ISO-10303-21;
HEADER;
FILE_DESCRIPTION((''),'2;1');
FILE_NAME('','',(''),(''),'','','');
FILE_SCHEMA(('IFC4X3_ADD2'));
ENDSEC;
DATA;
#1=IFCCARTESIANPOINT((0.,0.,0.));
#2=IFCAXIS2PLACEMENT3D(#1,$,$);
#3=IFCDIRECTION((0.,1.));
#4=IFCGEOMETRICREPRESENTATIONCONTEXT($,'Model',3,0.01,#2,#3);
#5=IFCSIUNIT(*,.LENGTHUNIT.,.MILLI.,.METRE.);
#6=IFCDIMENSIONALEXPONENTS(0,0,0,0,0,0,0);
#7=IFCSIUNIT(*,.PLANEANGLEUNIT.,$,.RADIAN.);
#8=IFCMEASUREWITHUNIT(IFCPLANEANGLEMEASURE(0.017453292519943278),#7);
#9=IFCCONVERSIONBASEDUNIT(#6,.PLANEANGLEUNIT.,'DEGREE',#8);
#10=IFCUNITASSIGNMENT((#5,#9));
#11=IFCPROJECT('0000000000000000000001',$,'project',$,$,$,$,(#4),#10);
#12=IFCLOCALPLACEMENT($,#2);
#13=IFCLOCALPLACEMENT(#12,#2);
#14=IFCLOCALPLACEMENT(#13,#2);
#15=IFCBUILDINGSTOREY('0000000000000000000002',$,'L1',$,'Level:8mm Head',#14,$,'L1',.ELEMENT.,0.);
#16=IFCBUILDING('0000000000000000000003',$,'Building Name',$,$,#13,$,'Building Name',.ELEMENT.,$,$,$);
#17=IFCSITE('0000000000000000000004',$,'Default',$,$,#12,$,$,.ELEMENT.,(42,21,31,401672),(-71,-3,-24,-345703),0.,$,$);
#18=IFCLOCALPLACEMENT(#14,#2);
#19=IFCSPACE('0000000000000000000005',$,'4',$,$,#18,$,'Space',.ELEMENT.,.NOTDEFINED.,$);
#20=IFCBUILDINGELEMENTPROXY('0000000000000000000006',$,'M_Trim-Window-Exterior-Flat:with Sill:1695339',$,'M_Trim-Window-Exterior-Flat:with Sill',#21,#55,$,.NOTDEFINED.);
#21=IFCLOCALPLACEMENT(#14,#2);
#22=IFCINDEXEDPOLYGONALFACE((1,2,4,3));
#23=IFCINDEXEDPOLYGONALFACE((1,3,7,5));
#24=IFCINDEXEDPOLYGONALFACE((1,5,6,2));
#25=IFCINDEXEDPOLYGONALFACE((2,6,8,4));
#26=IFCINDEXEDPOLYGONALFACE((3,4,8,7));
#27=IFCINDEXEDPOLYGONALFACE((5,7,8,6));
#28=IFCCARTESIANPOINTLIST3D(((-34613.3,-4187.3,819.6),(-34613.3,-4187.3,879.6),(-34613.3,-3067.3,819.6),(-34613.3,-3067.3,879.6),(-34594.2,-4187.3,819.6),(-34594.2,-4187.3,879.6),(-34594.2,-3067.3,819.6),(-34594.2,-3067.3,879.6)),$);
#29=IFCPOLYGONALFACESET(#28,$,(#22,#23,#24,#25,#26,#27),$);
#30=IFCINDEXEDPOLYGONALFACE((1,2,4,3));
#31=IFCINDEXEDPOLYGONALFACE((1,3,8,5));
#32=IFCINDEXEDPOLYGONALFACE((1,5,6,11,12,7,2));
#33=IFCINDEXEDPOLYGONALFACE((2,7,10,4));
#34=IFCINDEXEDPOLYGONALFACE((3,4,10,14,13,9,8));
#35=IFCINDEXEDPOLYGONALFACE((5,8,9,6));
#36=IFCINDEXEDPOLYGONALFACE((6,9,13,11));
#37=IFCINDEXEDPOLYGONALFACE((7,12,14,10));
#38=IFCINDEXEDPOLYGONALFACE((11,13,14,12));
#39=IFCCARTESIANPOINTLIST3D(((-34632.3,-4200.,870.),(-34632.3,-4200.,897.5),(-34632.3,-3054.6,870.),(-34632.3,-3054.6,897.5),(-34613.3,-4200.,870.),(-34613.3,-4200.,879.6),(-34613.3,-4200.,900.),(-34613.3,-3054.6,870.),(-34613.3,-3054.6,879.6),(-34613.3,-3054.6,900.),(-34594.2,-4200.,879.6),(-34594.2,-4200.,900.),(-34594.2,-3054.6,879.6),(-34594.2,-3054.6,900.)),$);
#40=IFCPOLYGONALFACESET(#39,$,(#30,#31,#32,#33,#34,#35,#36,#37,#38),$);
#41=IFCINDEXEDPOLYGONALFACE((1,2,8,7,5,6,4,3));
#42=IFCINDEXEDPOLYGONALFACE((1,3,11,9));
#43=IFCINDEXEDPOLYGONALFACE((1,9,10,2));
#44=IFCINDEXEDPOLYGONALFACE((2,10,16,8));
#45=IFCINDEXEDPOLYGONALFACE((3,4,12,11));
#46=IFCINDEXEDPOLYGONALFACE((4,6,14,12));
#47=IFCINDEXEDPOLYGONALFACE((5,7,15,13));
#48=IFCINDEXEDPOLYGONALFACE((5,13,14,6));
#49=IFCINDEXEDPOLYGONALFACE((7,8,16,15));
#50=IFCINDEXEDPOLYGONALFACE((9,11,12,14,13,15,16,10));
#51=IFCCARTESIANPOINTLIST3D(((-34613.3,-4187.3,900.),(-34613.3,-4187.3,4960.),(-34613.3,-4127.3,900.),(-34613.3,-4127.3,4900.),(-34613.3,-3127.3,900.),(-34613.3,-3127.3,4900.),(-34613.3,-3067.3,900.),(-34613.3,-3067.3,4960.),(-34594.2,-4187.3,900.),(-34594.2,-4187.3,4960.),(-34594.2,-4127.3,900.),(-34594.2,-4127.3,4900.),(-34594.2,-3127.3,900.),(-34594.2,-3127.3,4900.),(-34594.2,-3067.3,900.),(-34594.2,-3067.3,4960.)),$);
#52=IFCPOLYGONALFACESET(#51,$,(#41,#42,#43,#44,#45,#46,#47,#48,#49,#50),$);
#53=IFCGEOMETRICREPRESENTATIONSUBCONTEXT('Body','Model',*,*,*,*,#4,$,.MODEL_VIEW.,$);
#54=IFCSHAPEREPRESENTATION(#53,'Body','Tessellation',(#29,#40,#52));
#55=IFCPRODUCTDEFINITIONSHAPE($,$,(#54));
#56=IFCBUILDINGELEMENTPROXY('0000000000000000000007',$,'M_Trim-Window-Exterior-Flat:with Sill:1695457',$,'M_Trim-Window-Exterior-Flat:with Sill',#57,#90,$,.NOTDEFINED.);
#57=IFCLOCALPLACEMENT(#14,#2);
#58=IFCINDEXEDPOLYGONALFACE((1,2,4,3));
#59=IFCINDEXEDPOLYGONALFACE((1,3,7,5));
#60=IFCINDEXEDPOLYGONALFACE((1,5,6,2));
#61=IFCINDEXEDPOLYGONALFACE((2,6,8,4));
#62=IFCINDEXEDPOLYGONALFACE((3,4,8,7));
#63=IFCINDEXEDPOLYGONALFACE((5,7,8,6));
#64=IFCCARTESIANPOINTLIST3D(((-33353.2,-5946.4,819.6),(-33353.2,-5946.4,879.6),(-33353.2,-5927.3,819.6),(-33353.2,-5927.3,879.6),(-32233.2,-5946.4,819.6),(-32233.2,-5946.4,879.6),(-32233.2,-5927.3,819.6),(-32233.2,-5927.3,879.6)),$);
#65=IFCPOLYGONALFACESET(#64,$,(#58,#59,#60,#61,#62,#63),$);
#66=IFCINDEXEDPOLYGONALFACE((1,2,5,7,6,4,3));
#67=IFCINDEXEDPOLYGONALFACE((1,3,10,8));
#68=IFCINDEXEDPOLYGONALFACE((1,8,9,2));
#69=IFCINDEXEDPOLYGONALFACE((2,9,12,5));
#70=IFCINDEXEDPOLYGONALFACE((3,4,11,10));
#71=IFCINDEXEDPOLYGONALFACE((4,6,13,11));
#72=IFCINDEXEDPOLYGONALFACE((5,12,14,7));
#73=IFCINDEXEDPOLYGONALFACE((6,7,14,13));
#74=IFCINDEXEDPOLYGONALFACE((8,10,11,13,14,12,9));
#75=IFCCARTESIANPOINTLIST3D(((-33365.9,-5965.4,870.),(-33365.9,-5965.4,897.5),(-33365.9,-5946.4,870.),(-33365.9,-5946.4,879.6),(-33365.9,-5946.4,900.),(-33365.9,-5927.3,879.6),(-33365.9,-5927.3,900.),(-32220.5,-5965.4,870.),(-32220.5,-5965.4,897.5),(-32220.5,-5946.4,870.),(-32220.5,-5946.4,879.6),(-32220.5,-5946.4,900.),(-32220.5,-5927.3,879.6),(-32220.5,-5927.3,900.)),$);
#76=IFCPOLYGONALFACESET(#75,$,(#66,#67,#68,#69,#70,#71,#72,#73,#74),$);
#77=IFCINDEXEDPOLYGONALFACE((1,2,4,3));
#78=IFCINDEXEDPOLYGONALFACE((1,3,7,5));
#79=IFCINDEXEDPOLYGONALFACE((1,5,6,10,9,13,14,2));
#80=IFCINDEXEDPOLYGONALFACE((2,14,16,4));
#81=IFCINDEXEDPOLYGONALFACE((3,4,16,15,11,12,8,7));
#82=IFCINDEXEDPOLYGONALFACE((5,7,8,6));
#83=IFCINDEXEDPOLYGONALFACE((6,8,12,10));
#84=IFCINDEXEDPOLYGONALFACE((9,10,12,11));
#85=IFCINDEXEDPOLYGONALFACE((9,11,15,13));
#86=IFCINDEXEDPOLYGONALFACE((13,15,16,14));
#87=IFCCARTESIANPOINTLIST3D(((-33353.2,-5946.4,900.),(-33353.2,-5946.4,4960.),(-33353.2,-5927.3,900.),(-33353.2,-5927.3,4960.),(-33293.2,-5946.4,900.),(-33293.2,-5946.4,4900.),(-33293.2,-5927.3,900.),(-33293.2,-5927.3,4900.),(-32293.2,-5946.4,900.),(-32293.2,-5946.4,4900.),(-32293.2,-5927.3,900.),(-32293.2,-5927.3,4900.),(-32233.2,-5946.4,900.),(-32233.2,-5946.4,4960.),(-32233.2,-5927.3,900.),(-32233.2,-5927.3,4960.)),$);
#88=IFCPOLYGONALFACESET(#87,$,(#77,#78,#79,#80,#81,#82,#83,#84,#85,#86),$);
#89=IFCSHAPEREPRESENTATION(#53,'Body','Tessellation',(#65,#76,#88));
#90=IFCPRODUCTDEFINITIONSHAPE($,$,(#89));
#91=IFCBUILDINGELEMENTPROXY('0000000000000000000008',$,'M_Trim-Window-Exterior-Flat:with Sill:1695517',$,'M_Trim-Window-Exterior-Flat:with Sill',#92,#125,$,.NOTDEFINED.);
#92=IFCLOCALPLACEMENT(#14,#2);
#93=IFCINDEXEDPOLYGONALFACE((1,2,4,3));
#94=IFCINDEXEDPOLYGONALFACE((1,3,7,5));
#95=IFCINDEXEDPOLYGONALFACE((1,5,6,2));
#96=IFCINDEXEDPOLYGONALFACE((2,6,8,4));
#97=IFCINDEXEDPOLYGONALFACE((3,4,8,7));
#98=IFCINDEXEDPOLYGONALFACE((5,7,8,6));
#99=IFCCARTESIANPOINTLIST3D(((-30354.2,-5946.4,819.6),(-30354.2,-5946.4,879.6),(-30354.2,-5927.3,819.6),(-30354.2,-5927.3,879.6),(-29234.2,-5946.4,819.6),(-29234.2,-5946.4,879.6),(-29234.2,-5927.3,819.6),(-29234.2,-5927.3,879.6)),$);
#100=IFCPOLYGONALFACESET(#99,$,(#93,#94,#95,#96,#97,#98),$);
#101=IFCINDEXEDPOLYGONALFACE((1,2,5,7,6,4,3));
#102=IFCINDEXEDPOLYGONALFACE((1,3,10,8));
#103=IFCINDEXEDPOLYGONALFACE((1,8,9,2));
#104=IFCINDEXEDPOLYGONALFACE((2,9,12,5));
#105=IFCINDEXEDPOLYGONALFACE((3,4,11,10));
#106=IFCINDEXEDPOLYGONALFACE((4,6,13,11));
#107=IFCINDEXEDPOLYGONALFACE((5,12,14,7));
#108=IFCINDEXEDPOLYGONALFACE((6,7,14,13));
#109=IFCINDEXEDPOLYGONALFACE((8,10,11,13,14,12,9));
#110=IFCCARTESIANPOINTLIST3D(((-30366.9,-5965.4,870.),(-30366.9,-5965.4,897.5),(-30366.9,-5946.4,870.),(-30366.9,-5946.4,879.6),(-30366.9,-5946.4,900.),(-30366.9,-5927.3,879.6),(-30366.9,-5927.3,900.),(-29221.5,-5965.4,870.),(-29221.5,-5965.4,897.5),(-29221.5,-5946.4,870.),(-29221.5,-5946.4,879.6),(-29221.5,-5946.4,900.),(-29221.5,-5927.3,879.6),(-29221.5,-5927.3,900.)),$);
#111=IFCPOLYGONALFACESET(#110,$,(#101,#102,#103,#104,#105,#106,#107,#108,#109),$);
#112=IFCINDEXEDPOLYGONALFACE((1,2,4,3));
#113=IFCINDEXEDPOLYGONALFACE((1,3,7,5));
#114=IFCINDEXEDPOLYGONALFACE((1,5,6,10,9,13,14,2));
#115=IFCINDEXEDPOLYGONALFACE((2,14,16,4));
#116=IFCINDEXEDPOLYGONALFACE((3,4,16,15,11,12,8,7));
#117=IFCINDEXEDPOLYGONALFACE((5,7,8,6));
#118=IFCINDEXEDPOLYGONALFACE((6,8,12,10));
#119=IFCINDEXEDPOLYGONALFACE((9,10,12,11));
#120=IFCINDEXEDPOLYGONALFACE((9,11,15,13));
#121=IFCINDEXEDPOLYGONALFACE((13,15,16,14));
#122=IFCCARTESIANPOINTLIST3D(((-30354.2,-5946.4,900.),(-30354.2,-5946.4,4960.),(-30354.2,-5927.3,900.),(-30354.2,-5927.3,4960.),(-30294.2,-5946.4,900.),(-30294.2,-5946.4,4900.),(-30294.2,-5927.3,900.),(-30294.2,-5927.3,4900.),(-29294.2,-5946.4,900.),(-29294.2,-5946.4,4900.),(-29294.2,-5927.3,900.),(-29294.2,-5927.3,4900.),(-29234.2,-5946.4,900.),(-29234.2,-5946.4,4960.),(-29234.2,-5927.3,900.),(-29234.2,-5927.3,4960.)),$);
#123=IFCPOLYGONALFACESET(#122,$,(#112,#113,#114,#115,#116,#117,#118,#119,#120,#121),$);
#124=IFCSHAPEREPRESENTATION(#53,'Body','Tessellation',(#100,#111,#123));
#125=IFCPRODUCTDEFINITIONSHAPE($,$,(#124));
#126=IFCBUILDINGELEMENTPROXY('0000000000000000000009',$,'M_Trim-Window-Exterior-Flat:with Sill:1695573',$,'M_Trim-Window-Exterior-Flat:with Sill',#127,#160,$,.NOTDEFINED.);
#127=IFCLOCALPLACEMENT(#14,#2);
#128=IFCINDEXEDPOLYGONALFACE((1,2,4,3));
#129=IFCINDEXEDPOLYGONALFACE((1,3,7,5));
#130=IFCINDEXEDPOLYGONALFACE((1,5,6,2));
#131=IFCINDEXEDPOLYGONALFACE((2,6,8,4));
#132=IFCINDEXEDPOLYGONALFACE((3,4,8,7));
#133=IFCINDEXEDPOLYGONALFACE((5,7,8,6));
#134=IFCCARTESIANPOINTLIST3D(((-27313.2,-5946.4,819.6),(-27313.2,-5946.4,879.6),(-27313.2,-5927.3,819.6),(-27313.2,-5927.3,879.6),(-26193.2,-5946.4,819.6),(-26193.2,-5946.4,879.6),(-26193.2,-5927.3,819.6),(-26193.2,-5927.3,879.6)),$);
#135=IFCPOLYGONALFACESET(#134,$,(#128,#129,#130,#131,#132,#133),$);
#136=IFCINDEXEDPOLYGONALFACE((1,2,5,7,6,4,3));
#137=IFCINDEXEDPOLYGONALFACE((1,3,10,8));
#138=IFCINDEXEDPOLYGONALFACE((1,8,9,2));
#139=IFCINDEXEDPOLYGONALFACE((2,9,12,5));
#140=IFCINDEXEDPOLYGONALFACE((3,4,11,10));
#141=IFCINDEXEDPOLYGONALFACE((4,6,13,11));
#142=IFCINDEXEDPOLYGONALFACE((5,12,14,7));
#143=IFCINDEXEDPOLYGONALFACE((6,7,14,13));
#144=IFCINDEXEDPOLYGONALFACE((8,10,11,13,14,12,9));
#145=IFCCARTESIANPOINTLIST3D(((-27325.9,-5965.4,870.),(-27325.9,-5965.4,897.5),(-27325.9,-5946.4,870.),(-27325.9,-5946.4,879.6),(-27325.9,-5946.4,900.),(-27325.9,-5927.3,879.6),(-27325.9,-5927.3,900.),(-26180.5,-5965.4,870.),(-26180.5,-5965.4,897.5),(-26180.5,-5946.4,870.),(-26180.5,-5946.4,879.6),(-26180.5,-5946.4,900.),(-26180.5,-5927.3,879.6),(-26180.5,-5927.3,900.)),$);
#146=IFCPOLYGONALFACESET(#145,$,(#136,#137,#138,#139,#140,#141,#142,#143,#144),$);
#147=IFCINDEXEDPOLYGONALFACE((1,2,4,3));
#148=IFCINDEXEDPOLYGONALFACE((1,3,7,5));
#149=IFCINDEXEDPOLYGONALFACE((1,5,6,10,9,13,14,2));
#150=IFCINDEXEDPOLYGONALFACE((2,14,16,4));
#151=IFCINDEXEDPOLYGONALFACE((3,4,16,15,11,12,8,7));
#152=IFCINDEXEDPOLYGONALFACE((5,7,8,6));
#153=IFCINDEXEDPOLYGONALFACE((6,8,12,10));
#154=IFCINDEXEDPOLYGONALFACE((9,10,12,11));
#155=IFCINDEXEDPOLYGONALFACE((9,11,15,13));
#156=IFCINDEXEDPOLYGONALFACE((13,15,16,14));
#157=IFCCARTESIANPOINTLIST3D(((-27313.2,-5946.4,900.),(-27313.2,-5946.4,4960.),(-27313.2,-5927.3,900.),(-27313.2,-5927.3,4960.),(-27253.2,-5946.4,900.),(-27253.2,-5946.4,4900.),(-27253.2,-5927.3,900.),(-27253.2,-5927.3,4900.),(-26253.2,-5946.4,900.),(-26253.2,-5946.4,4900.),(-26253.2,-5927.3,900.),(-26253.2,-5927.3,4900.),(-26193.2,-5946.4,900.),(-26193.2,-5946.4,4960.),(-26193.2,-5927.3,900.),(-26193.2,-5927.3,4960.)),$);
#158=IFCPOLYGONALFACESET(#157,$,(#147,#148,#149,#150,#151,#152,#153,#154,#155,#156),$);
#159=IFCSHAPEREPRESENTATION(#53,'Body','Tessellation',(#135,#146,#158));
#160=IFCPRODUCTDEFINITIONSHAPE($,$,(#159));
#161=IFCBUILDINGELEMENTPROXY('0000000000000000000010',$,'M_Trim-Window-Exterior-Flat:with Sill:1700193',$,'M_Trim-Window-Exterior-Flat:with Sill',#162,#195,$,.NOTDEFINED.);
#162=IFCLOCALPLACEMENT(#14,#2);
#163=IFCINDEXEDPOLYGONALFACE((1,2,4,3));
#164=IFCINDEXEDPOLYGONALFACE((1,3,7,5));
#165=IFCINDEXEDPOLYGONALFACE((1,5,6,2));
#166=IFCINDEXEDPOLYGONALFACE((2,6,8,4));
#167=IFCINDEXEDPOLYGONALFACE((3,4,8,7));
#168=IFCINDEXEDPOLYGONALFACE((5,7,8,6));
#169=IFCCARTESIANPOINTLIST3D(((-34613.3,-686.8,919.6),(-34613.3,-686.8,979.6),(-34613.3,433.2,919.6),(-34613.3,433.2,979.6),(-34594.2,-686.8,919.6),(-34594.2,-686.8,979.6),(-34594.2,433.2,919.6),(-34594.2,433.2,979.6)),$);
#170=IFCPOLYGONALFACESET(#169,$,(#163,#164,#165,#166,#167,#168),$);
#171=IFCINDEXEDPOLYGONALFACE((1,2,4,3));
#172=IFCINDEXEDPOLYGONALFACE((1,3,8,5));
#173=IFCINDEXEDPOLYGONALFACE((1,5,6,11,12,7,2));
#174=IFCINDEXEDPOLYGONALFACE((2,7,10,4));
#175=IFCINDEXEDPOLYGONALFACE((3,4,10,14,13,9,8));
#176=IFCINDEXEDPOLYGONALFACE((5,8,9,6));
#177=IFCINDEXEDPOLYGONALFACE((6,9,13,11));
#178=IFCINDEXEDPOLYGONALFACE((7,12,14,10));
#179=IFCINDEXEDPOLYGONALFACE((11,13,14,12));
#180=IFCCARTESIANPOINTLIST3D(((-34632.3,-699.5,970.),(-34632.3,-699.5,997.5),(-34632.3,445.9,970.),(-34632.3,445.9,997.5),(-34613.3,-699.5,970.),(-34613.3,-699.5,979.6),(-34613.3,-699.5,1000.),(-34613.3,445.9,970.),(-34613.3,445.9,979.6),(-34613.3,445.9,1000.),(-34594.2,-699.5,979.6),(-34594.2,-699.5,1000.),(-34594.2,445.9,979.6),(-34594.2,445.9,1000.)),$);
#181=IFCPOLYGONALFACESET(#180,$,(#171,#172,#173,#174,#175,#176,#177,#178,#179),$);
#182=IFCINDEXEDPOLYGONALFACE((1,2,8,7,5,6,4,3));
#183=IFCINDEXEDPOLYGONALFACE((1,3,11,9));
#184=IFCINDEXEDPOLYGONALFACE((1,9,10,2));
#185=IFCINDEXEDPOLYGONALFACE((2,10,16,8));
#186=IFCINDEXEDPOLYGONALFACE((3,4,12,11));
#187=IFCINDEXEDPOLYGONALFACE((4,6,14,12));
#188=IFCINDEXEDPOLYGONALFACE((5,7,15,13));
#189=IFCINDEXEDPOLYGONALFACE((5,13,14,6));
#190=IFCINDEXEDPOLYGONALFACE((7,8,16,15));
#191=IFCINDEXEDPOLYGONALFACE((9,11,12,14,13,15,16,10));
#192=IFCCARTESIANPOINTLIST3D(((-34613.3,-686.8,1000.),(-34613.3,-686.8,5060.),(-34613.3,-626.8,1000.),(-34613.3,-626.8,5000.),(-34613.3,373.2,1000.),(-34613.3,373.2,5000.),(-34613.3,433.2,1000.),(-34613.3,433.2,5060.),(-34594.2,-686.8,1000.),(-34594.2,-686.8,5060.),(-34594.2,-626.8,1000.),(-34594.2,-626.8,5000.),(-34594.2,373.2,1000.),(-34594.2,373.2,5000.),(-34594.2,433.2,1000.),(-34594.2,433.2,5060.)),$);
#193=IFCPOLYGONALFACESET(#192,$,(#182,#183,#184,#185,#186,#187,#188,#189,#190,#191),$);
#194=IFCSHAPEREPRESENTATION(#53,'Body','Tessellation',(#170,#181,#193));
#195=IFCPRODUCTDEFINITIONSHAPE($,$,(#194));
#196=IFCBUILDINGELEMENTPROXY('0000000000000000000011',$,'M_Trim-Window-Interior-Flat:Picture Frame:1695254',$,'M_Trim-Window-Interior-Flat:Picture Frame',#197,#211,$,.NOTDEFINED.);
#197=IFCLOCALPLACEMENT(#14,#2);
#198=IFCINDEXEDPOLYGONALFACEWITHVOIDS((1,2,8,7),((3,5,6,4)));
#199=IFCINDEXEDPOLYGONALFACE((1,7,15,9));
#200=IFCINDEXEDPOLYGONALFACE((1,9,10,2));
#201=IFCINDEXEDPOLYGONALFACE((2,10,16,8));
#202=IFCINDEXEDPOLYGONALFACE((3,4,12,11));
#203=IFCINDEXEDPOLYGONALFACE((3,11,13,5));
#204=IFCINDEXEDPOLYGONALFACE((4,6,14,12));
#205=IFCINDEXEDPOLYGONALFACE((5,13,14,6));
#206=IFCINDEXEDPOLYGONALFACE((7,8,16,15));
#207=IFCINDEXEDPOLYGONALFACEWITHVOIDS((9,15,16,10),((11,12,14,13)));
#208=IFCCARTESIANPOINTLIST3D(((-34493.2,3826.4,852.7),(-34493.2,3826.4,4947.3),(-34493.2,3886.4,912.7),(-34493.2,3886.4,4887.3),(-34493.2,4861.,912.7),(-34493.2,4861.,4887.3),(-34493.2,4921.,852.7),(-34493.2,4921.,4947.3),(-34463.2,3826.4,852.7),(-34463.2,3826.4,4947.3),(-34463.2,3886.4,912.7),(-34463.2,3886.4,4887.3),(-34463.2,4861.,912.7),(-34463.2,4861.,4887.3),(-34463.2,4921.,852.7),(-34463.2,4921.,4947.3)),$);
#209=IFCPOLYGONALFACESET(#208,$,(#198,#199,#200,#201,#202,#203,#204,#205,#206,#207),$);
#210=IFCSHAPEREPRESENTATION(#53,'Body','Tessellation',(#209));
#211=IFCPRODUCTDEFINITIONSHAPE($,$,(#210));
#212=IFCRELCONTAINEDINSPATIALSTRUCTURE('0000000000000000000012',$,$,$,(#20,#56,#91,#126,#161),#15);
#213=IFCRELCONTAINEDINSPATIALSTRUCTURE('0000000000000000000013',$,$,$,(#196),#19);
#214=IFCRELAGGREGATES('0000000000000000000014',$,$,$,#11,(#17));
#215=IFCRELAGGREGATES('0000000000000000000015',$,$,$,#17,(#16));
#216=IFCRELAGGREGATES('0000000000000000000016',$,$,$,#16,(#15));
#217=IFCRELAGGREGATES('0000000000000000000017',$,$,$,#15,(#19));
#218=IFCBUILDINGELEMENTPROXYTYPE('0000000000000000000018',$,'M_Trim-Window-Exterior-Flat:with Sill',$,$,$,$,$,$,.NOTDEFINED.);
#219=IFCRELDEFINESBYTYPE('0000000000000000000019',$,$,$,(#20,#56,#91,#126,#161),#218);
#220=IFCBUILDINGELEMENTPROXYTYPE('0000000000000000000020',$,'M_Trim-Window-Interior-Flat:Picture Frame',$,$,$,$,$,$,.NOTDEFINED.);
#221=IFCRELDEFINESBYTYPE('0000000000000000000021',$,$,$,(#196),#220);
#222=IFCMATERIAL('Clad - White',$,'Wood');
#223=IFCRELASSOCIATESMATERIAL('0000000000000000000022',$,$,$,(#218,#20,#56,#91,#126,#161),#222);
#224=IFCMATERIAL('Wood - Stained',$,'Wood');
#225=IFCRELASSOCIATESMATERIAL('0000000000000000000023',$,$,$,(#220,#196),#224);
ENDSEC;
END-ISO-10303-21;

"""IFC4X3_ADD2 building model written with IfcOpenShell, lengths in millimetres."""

from ifc_helpers import new_model, entity, si_unit, converted_unit, direction, frame, frame_2d, origin, place, context, subcontext, project, spatial, polyline, rectangle, outline, extrude, source, transform, mapped, material, type_object, type_shapes, element, save


model = new_model("IFC4X3_ADD2")

# Units and contexts
model_context = context("Model", 3, precision=0.01, world=origin(), true_north=direction((0.0, 1.0)))
body_context = subcontext(model_context, "Body", "Model", "MODEL_VIEW")
ifc_project = project(units=[si_unit("LENGTHUNIT", "METRE", prefix="MILLI"), converted_unit("PLANEANGLEUNIT", "DEGREE", entity("IfcPlaneAngleMeasure", 0.017453292519943278), si_unit("PLANEANGLEUNIT", "RADIAN"), dimensions=[0, 0, 0, 0, 0, 0, 0])], contexts=[model_context])

# Site, building, storey
site_placement = place(None, origin())
site = spatial("IfcSite", under=ifc_project, at=site_placement, Name="Default", CompositionType="ELEMENT", RefLatitude=(42, 21, 31, 401672), RefLongitude=(-71, -3, -24, -345703), RefElevation=0.0)
building_placement = place(site_placement, origin())
building = spatial("IfcBuilding", under=site, at=building_placement, Name="Building Name", LongName="Building Name", CompositionType="ELEMENT")
storey_placement = place(building_placement, origin())
storey = spatial("IfcBuildingStorey", under=building, at=storey_placement, Name="L1", ObjectType="Level:8mm Head", LongName="L1", CompositionType="ELEMENT", Elevation=0.0)

# Building element proxies
ifc_material_1 = material(Name="Clad - White", Category="Wood")
ifc_material_2 = material(Name="Wood - Stained", Category="Wood")
building_element_proxy_type_1 = type_object("IfcBuildingElementProxyType", Name="M_Trim-Window-Exterior-Flat:with Sill", PredefinedType="NOTDEFINED", material=ifc_material_1)
shared_shape_1 = source(origin(), body_context, "Body", "SweptSolid", [
    extrude(rectangle(XDim=1120.0, YDim=60.0, at=frame_2d((0.0, 0.0), x_axis=(1.0, 0.0))), frame((0.0, -4050.4, 0.0), z_axis=(0.0, 0.0, 1.0), x_axis=(-1.0, 0.0, 0.0)), (0.0, 0.0, 1.0), 19.0),
    extrude(outline(polyline([(-19.0, -15.2), (0.0, -15.2), (0.0, -5.7), (19.0, -5.7), (19.0, 14.8), (0.0, 14.8), (-19.0, 12.3), (-19.0, -15.2)])), frame((-572.7, -4014.8, 19.0), z_axis=(1.0, 0.0, 0.0), x_axis=(0.0, 0.0, -1.0)), (0.0, 0.0, 1.0), 1145.4),
    extrude(outline(polyline([(-2045.0, -560.0), (2015.0, -560.0), (2015.0, -500.0), (-1985.0, -500.0), (-1985.0, 500.0), (2015.0, 500.0), (2015.0, 560.0), (-2045.0, 560.0), (-2045.0, -560.0)])), frame((0.0, -1985.0, 0.0), z_axis=(0.0, 0.0, 1.0), x_axis=(0.0, -1.0, 0.0)), (0.0, 0.0, 1.0), 19.0),
])
type_shapes(building_element_proxy_type_1, [shared_shape_1])
for number, where, z_axis, x_axis, name in (
    (1, (-34594.2, -3627.3, 4900.0), (-1.0, 0.0, 0.0), (0.0, -1.0, 0.0), "M_Trim-Window-Exterior-Flat:with Sill:1695339"),
    (2, (-32793.2, -5927.3, 4900.0), (0.0, -1.0, 0.0), (1.0, 0.0, 0.0), "M_Trim-Window-Exterior-Flat:with Sill:1695457"),
    (3, (-29794.2, -5927.3, 4900.0), (0.0, -1.0, 0.0), (1.0, 0.0, 0.0), "M_Trim-Window-Exterior-Flat:with Sill:1695517"),
    (4, (-26753.2, -5927.3, 4900.0), (0.0, -1.0, 0.0), (1.0, 0.0, 0.0), "M_Trim-Window-Exterior-Flat:with Sill:1695573"),
    (5, (-34594.2, -126.8, 5000.0), (-1.0, 0.0, 0.0), (0.0, -1.0, 0.0), "M_Trim-Window-Exterior-Flat:with Sill:1700193"),
):
    element("IfcBuildingElementProxy", number, at=place(storey_placement, frame(where, z_axis=z_axis, x_axis=x_axis)), inside=storey, type_object=building_element_proxy_type_1, material=ifc_material_1, Name=name, ObjectType="M_Trim-Window-Exterior-Flat:with Sill", PredefinedType="NOTDEFINED", context=body_context, shape_type="MappedRepresentation", body=[
        mapped(shared_shape_1, transform((0.0, 0.0, 0.0), scale=1.0)),
    ])

# Shared definitions
space_1_placement = place(storey_placement, origin())
space_1 = spatial("IfcSpace", under=storey, at=space_1_placement, Name="4", LongName="Space", CompositionType="ELEMENT", PredefinedType="NOTDEFINED")

# Building element proxy
building_element_proxy_type_2 = type_object("IfcBuildingElementProxyType", Name="M_Trim-Window-Interior-Flat:Picture Frame", PredefinedType="NOTDEFINED", material=ifc_material_2)
shared_shape_2 = source(origin(), body_context, "Body", "SweptSolid", [
    extrude(outline(polyline([(-547.3, -2047.3), (547.3, -2047.3), (547.3, 2047.3), (-547.3, 2047.3), (-547.3, -2047.3)]), holes=[polyline([(-487.3, -1987.3), (-487.3, 1987.3), (487.3, 1987.3), (487.3, -1987.3), (-487.3, -1987.3)])]), frame((0.0, -2000.0, 0.0), z_axis=(0.0, 0.0, 1.0), x_axis=(-1.0, 0.0, 0.0)), (0.0, 0.0, 1.0), 30.0),
])
type_shapes(building_element_proxy_type_2, [shared_shape_2])
proxy_1_placement = place(space_1_placement, frame((-34493.2, 4373.7, 4900.0), z_axis=(1.0, 0.0, 0.0), x_axis=(0.0, 1.0, 0.0)))
element("IfcBuildingElementProxy", 6, at=proxy_1_placement, inside=space_1, type_object=building_element_proxy_type_2, material=ifc_material_2, Name="M_Trim-Window-Interior-Flat:Picture Frame:1695254", ObjectType="M_Trim-Window-Interior-Flat:Picture Frame", PredefinedType="NOTDEFINED", context=body_context, shape_type="MappedRepresentation", body=[
    mapped(shared_shape_2, transform((0.0, 0.0, 0.0), scale=1.0)),
])

save(model, "model.ifc")
